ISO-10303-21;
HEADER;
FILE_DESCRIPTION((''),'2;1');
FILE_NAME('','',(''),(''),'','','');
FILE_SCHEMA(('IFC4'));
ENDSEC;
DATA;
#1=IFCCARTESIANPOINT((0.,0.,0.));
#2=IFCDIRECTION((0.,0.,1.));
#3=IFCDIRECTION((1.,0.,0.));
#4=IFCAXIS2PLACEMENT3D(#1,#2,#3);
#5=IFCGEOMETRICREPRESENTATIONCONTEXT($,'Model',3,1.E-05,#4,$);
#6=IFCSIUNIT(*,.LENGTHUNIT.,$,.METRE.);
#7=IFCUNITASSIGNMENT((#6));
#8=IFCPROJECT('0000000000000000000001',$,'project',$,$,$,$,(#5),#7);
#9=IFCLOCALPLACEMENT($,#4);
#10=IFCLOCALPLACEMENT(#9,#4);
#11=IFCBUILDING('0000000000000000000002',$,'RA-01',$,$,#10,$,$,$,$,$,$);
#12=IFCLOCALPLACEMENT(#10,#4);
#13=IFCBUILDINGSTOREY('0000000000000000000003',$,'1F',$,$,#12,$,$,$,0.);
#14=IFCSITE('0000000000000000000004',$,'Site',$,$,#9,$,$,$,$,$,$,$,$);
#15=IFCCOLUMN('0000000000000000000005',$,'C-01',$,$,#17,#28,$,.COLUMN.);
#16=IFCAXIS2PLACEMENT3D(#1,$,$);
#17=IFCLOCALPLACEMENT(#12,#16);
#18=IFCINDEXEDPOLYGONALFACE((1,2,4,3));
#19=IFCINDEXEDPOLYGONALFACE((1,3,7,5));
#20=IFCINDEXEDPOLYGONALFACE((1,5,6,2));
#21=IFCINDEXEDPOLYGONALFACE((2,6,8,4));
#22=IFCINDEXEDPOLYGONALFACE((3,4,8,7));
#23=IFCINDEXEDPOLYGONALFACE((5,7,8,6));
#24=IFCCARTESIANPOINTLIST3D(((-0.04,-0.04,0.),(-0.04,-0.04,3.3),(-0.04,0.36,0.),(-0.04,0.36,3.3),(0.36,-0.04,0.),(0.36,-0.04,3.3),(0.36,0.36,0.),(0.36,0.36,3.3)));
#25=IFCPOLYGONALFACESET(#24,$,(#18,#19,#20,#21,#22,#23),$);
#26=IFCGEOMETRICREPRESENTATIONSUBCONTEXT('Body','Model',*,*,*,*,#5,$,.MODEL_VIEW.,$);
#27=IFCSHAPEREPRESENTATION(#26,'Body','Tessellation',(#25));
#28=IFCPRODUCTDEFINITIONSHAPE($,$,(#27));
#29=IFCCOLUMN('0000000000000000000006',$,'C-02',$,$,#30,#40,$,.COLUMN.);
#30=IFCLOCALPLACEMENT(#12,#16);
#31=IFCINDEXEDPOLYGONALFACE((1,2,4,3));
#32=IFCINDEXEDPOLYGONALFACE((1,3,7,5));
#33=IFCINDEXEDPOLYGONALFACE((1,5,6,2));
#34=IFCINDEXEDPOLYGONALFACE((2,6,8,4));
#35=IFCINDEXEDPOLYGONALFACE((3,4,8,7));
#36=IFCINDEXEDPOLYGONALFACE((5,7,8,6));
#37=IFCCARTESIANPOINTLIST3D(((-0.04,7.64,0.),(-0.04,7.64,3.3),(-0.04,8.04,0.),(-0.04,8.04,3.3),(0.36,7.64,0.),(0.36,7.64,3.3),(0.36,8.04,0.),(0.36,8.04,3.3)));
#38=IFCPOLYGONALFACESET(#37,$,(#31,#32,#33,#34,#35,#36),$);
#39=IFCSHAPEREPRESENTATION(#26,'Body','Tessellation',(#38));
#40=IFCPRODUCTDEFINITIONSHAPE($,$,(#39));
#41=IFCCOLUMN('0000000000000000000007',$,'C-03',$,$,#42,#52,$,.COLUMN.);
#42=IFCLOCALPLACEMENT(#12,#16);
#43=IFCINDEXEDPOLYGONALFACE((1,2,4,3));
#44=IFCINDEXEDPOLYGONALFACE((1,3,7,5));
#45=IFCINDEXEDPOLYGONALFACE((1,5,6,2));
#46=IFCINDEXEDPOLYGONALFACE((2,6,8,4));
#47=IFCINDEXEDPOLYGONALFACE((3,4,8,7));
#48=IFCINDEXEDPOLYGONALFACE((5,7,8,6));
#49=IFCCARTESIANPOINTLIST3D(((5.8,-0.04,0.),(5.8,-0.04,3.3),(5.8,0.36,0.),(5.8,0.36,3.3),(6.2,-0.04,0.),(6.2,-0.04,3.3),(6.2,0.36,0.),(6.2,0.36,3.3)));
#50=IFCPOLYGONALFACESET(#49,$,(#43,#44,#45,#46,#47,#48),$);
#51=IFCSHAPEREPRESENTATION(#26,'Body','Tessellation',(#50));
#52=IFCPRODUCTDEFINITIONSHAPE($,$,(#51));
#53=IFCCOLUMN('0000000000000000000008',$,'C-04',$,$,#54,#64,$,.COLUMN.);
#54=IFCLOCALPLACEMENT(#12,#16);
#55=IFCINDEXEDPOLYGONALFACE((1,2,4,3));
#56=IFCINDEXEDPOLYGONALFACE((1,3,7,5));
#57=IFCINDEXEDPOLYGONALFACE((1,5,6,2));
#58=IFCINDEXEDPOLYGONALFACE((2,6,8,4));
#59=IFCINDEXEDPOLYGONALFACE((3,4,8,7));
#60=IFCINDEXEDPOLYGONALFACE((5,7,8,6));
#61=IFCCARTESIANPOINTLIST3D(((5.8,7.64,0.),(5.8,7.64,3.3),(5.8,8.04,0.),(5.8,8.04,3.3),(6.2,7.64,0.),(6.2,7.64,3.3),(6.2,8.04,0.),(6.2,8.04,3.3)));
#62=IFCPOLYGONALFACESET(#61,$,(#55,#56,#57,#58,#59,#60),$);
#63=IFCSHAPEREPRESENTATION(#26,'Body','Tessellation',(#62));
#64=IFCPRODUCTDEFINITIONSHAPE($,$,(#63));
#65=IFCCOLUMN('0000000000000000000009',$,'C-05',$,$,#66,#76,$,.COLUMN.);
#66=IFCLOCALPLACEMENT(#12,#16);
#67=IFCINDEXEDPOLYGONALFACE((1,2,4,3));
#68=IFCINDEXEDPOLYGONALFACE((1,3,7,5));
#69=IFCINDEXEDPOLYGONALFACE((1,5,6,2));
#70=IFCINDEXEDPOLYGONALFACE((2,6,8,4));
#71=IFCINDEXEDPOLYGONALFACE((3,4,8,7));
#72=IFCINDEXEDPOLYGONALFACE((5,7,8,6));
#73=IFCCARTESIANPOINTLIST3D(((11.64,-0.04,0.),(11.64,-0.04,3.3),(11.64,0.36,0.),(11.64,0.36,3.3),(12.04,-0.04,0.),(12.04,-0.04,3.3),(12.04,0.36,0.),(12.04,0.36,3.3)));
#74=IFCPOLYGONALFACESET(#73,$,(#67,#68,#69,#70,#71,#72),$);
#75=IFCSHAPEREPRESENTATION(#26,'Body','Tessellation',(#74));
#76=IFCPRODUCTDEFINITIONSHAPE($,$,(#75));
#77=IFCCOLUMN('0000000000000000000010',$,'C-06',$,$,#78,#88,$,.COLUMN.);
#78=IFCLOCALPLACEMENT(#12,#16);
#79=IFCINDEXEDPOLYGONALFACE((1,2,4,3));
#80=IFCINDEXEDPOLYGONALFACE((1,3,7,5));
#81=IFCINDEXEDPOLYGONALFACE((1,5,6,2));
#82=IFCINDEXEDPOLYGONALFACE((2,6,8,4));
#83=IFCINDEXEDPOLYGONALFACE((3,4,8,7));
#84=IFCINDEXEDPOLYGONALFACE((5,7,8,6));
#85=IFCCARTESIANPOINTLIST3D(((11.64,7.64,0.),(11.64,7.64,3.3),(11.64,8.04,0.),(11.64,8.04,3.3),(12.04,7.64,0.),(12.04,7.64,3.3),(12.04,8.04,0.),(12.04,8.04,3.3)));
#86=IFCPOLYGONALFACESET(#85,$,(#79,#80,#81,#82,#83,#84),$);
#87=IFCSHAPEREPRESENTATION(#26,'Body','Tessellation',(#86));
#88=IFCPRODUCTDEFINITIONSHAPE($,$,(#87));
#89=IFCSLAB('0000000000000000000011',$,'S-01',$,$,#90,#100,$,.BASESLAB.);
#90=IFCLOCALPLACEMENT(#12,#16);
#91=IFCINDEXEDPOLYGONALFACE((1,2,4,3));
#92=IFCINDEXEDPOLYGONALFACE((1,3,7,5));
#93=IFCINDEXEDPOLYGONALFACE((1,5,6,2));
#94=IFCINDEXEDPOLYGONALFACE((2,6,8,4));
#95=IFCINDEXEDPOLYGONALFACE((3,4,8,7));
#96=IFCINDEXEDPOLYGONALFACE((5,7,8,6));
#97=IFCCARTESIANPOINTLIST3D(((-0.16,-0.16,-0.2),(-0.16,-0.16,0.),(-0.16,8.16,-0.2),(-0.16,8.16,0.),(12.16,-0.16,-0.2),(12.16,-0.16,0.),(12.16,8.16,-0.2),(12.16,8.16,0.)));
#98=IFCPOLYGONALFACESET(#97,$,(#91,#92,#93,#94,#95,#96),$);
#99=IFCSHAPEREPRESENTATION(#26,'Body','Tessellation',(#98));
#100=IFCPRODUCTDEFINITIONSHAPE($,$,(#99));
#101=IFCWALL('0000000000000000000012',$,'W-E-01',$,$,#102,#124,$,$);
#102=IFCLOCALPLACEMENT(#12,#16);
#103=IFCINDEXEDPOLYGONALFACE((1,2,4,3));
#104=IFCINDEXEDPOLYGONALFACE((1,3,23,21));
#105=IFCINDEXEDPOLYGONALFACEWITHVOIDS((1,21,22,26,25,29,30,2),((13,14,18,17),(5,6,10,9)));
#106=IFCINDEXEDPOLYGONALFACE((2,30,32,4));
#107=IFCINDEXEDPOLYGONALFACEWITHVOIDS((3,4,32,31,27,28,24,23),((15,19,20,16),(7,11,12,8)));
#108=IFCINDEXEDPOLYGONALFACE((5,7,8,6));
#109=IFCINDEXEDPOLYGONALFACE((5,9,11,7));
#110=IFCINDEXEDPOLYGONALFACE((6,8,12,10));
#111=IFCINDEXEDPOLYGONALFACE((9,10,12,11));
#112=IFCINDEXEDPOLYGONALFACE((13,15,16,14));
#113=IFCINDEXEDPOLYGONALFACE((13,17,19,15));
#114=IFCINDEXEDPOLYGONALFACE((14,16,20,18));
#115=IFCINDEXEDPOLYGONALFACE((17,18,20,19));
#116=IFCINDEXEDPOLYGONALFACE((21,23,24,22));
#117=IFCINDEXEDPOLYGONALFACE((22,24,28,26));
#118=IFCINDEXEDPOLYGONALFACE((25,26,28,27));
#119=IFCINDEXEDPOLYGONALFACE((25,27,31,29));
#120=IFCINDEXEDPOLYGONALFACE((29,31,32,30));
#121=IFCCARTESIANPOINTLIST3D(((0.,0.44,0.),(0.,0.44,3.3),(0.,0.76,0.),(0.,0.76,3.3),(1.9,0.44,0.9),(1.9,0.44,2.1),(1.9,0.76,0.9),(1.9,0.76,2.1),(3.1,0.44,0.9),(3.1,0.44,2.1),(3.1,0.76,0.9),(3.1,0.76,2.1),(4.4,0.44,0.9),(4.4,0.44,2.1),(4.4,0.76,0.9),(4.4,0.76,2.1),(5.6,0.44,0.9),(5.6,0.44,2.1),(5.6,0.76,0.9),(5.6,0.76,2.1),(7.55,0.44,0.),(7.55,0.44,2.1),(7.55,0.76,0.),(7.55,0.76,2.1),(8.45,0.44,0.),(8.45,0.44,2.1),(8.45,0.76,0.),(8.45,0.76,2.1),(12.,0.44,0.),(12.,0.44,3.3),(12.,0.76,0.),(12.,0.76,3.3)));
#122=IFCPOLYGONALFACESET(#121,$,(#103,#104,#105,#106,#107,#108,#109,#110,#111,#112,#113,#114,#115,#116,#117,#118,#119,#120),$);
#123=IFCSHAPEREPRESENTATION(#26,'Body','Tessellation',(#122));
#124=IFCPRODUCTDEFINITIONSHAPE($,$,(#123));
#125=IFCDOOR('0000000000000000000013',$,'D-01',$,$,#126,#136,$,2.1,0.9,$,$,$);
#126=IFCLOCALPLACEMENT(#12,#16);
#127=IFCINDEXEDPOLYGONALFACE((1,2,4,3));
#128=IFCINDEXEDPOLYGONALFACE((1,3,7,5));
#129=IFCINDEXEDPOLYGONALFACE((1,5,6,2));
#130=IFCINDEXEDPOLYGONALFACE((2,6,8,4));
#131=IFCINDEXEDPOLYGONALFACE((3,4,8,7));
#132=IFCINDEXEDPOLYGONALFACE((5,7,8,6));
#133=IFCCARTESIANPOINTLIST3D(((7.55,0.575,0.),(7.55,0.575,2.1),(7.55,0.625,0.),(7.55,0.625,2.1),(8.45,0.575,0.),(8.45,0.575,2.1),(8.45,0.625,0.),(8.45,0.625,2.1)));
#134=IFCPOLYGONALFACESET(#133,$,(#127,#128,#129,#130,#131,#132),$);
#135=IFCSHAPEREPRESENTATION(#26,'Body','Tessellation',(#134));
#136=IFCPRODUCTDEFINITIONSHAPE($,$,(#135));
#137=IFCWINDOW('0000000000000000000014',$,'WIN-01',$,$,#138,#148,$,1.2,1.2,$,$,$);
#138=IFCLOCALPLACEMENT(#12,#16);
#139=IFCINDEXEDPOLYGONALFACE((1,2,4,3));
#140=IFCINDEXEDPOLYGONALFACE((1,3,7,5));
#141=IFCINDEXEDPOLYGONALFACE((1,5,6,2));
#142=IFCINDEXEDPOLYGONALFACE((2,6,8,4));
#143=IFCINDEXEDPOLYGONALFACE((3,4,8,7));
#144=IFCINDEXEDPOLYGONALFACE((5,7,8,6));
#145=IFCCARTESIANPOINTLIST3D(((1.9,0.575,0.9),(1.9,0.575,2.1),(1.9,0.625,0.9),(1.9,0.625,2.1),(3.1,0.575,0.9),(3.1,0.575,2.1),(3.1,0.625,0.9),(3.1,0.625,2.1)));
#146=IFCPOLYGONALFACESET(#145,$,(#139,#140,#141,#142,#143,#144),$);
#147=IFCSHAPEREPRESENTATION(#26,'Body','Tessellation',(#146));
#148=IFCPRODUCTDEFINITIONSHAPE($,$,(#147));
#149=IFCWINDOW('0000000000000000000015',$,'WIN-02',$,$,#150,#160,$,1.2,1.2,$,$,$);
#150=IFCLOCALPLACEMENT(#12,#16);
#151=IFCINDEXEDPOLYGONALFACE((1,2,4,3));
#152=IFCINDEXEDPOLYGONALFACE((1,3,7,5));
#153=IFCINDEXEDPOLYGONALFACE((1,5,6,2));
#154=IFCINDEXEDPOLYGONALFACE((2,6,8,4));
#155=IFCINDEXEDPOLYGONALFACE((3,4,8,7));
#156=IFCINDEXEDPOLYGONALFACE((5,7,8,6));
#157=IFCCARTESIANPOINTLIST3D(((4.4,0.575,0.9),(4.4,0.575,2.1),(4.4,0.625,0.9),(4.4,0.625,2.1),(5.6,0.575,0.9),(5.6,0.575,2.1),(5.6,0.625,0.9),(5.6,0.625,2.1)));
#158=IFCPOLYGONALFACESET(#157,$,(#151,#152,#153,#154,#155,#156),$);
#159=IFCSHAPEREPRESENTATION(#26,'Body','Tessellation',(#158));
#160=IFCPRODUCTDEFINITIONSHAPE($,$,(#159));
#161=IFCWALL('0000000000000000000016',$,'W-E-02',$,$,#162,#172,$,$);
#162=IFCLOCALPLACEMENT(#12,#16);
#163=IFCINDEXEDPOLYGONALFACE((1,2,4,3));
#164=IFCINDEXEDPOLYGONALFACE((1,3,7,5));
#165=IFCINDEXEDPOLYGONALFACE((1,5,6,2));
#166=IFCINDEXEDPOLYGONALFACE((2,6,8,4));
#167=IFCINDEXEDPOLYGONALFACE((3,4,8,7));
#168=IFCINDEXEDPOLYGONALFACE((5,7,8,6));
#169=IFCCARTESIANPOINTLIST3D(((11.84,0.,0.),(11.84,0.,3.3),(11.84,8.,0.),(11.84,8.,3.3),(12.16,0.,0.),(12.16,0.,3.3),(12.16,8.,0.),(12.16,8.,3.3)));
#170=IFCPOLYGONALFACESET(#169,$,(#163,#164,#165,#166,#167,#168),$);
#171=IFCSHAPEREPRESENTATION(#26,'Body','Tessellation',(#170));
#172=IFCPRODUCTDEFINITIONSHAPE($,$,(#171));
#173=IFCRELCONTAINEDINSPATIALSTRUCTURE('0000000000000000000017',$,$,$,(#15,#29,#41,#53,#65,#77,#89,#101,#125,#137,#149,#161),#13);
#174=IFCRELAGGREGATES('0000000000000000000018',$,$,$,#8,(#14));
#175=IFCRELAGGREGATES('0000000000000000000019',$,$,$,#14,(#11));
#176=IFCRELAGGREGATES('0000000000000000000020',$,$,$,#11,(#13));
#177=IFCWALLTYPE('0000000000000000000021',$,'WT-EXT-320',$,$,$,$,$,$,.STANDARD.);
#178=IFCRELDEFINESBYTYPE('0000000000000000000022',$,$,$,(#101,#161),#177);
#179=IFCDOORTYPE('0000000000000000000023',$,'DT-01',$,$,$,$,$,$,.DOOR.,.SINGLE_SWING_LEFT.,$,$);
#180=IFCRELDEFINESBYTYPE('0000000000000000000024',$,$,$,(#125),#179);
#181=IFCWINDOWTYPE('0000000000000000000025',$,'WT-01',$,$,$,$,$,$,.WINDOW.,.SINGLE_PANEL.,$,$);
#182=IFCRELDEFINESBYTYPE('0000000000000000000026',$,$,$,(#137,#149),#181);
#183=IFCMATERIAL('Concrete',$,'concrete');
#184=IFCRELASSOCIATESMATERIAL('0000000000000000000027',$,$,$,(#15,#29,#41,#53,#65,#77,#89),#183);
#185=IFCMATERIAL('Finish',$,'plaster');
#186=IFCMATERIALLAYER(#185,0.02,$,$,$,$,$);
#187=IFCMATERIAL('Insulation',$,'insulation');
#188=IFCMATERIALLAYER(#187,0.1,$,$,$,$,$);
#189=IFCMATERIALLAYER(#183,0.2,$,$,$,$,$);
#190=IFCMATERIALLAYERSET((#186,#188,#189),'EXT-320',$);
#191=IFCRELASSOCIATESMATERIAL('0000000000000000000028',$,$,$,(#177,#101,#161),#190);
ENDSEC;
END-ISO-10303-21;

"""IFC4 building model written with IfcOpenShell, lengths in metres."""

from ifc_helpers import new_model, si_unit, frame, frame_2d, origin_with_axes, origin_2d_with_axis, place, context, subcontext, project, spatial, polyline, rectangle, outline, extrude, material, layer, layer_set, layer_usage, type_object, element, fill, save


model = new_model("IFC4")

# Units and contexts
model_context = context("Model", 3, precision=1e-05, world=origin_with_axes())
body_context = subcontext(model_context, "Body", "Model", "MODEL_VIEW")
ifc_project = project(units=[si_unit("LENGTHUNIT", "METRE")], contexts=[model_context])

# Site, building, storey
site_placement = place(None, origin_with_axes())
site = spatial("IfcSite", under=ifc_project, at=site_placement, Name="Site")
building_placement = place(site_placement, origin_with_axes())
building = spatial("IfcBuilding", under=site, at=building_placement, Name="RA-01")
storey_placement = place(building_placement, origin_with_axes())
storey = spatial("IfcBuildingStorey", under=building, at=storey_placement, Name="1F", Elevation=0.0)

# Columns
ifc_material_1 = material(Name="Concrete", Category="concrete")
for number, where, z_axis, x_axis, name in (
    (1, (0.16, 0.16, 0.0), (0.0, 0.0, 1.0), (1.0, 0.0, 0.0), "C-01"),
    (2, (0.16, 7.84, 0.0), (0.0, 0.0, 1.0), (1.0, 0.0, 0.0), "C-02"),
    (3, (6.0, 0.16, 0.0), (0.0, 0.0, 1.0), (1.0, 0.0, 0.0), "C-03"),
    (4, (6.0, 7.84, 0.0), (0.0, 0.0, 1.0), (1.0, 0.0, 0.0), "C-04"),
    (5, (11.84, 0.16, 0.0), (0.0, 0.0, 1.0), (1.0, 0.0, 0.0), "C-05"),
    (6, (11.84, 7.84, 0.0), (0.0, 0.0, 1.0), (1.0, 0.0, 0.0), "C-06"),
):
    element("IfcColumn", number, at=place(storey_placement, frame(where, z_axis=z_axis, x_axis=x_axis)), inside=storey, material=ifc_material_1, Name=name, PredefinedType="COLUMN", context=body_context, shape_type="SweptSolid", body=[
        extrude(rectangle(XDim=0.4, YDim=0.4, at=origin_2d_with_axis()), origin_with_axes(), (0.0, 0.0, 1.0), 3.3),
    ])

# Slab
slab_placement = place(storey_placement, frame((0.0, 0.0, -0.2), z_axis=(0.0, 0.0, 1.0), x_axis=(1.0, 0.0, 0.0)))
element("IfcSlab", 7, at=slab_placement, inside=storey, material=ifc_material_1, Name="S-01", PredefinedType="BASESLAB", context=body_context, shape_type="SweptSolid", body=[
    extrude(outline(polyline([(-0.16, -0.16), (12.16, -0.16), (12.16, 8.16), (-0.16, 8.16), (-0.16, -0.16)])), origin_with_axes(), (0.0, 0.0, 1.0), 0.2),
])

# Wall, openings, door, windows
ifc_material_2 = material(Name="Finish", Category="plaster")
ifc_layer_1 = layer(ifc_material_2, 0.02)
ifc_material_3 = material(Name="Insulation", Category="insulation")
ifc_layer_2 = layer(ifc_material_3, 0.1)
ifc_layer_3 = layer(ifc_material_1, 0.2)
ifc_layer_set_1 = layer_set([ifc_layer_1, ifc_layer_2, ifc_layer_3], Name="EXT-320")
ifc_layer_usage_1 = layer_usage(ifc_layer_set_1, "AXIS2", "POSITIVE", -0.16)
wall_type_1 = type_object("IfcWallType", Name="WT-EXT-320", PredefinedType="STANDARD", material=ifc_layer_set_1)
wall_1_placement = place(storey_placement, frame((0.0, 0.6, 0.0), z_axis=(0.0, 0.0, 1.0), x_axis=(1.0, 0.0, 0.0)))
wall_1 = element("IfcWall", 8, at=wall_1_placement, inside=storey, type_object=wall_type_1, material=ifc_layer_usage_1, Name="W-E-01", context=body_context, shape_type="SweptSolid", body=[
    extrude(rectangle(XDim=12.0, YDim=0.32, at=frame_2d((6.0, 0.0), x_axis=(1.0, 0.0))), origin_with_axes(), (0.0, 0.0, 1.0), 3.3),
])
opening_1_placement = place(wall_1_placement, frame((8.0, 0.0, 0.0), z_axis=(0.0, 0.0, 1.0), x_axis=(1.0, 0.0, 0.0)))
opening_1 = element("IfcOpeningElement", 9, at=opening_1_placement, cuts=wall_1, PredefinedType="OPENING", context=body_context, shape_type="SweptSolid", body=[
    extrude(rectangle(XDim=0.9, YDim=0.42, at=origin_2d_with_axis()), origin_with_axes(), (0.0, 0.0, 1.0), 2.1),
])
opening_2_placement = place(wall_1_placement, frame((2.5, 0.0, 0.9), z_axis=(0.0, 0.0, 1.0), x_axis=(1.0, 0.0, 0.0)))
opening_2 = element("IfcOpeningElement", 10, at=opening_2_placement, cuts=wall_1, PredefinedType="OPENING", context=body_context, shape_type="SweptSolid", body=[
    extrude(rectangle(XDim=1.2, YDim=0.42, at=origin_2d_with_axis()), origin_with_axes(), (0.0, 0.0, 1.0), 1.2),
])
opening_3_placement = place(wall_1_placement, frame((5.0, 0.0, 0.9), z_axis=(0.0, 0.0, 1.0), x_axis=(1.0, 0.0, 0.0)))
opening_3 = element("IfcOpeningElement", 11, at=opening_3_placement, cuts=wall_1, PredefinedType="OPENING", context=body_context, shape_type="SweptSolid", body=[
    extrude(rectangle(XDim=1.2, YDim=0.42, at=origin_2d_with_axis()), origin_with_axes(), (0.0, 0.0, 1.0), 1.2),
])
door_type_1 = type_object("IfcDoorType", Name="DT-01", OperationType="SINGLE_SWING_LEFT", PredefinedType="DOOR")
door_1_placement = place(opening_1_placement, origin_with_axes())
door_1 = element("IfcDoor", 12, at=door_1_placement, inside=storey, type_object=door_type_1, Name="D-01", OverallHeight=2.1, OverallWidth=0.9, context=body_context, shape_type="SweptSolid", body=[
    extrude(rectangle(XDim=0.9, YDim=0.05, at=origin_2d_with_axis()), origin_with_axes(), (0.0, 0.0, 1.0), 2.1),
])
fill(opening_1, door_1)
window_type_1 = type_object("IfcWindowType", Name="WT-01", PartitioningType="SINGLE_PANEL", PredefinedType="WINDOW")
window_1_placement = place(opening_2_placement, origin_with_axes())
window_1 = element("IfcWindow", 13, at=window_1_placement, inside=storey, type_object=window_type_1, Name="WIN-01", OverallHeight=1.2, OverallWidth=1.2, context=body_context, shape_type="SweptSolid", body=[
    extrude(rectangle(XDim=1.2, YDim=0.05, at=origin_2d_with_axis()), origin_with_axes(), (0.0, 0.0, 1.0), 1.2),
])
fill(opening_2, window_1)
window_2_placement = place(opening_3_placement, origin_with_axes())
window_2 = element("IfcWindow", 14, at=window_2_placement, inside=storey, type_object=window_type_1, Name="WIN-02", OverallHeight=1.2, OverallWidth=1.2, context=body_context, shape_type="SweptSolid", body=[
    extrude(rectangle(XDim=1.2, YDim=0.05, at=origin_2d_with_axis()), origin_with_axes(), (0.0, 0.0, 1.0), 1.2),
])
fill(opening_3, window_2)

# Wall
ifc_layer_usage_2 = layer_usage(ifc_layer_set_1, "AXIS2", "POSITIVE", -0.16)
wall_2_placement = place(storey_placement, frame((12.0, 0.0, 0.0), z_axis=(0.0, 0.0, 1.0), x_axis=(0.0, 1.0, 0.0)))
element("IfcWall", 15, at=wall_2_placement, inside=storey, type_object=wall_type_1, material=ifc_layer_usage_2, Name="W-E-02", context=body_context, shape_type="SweptSolid", body=[
    extrude(rectangle(XDim=8.0, YDim=0.32, at=frame_2d((4.0, 0.0), x_axis=(1.0, 0.0))), origin_with_axes(), (0.0, 0.0, 1.0), 3.3),
])

save(model, "model.ifc")
